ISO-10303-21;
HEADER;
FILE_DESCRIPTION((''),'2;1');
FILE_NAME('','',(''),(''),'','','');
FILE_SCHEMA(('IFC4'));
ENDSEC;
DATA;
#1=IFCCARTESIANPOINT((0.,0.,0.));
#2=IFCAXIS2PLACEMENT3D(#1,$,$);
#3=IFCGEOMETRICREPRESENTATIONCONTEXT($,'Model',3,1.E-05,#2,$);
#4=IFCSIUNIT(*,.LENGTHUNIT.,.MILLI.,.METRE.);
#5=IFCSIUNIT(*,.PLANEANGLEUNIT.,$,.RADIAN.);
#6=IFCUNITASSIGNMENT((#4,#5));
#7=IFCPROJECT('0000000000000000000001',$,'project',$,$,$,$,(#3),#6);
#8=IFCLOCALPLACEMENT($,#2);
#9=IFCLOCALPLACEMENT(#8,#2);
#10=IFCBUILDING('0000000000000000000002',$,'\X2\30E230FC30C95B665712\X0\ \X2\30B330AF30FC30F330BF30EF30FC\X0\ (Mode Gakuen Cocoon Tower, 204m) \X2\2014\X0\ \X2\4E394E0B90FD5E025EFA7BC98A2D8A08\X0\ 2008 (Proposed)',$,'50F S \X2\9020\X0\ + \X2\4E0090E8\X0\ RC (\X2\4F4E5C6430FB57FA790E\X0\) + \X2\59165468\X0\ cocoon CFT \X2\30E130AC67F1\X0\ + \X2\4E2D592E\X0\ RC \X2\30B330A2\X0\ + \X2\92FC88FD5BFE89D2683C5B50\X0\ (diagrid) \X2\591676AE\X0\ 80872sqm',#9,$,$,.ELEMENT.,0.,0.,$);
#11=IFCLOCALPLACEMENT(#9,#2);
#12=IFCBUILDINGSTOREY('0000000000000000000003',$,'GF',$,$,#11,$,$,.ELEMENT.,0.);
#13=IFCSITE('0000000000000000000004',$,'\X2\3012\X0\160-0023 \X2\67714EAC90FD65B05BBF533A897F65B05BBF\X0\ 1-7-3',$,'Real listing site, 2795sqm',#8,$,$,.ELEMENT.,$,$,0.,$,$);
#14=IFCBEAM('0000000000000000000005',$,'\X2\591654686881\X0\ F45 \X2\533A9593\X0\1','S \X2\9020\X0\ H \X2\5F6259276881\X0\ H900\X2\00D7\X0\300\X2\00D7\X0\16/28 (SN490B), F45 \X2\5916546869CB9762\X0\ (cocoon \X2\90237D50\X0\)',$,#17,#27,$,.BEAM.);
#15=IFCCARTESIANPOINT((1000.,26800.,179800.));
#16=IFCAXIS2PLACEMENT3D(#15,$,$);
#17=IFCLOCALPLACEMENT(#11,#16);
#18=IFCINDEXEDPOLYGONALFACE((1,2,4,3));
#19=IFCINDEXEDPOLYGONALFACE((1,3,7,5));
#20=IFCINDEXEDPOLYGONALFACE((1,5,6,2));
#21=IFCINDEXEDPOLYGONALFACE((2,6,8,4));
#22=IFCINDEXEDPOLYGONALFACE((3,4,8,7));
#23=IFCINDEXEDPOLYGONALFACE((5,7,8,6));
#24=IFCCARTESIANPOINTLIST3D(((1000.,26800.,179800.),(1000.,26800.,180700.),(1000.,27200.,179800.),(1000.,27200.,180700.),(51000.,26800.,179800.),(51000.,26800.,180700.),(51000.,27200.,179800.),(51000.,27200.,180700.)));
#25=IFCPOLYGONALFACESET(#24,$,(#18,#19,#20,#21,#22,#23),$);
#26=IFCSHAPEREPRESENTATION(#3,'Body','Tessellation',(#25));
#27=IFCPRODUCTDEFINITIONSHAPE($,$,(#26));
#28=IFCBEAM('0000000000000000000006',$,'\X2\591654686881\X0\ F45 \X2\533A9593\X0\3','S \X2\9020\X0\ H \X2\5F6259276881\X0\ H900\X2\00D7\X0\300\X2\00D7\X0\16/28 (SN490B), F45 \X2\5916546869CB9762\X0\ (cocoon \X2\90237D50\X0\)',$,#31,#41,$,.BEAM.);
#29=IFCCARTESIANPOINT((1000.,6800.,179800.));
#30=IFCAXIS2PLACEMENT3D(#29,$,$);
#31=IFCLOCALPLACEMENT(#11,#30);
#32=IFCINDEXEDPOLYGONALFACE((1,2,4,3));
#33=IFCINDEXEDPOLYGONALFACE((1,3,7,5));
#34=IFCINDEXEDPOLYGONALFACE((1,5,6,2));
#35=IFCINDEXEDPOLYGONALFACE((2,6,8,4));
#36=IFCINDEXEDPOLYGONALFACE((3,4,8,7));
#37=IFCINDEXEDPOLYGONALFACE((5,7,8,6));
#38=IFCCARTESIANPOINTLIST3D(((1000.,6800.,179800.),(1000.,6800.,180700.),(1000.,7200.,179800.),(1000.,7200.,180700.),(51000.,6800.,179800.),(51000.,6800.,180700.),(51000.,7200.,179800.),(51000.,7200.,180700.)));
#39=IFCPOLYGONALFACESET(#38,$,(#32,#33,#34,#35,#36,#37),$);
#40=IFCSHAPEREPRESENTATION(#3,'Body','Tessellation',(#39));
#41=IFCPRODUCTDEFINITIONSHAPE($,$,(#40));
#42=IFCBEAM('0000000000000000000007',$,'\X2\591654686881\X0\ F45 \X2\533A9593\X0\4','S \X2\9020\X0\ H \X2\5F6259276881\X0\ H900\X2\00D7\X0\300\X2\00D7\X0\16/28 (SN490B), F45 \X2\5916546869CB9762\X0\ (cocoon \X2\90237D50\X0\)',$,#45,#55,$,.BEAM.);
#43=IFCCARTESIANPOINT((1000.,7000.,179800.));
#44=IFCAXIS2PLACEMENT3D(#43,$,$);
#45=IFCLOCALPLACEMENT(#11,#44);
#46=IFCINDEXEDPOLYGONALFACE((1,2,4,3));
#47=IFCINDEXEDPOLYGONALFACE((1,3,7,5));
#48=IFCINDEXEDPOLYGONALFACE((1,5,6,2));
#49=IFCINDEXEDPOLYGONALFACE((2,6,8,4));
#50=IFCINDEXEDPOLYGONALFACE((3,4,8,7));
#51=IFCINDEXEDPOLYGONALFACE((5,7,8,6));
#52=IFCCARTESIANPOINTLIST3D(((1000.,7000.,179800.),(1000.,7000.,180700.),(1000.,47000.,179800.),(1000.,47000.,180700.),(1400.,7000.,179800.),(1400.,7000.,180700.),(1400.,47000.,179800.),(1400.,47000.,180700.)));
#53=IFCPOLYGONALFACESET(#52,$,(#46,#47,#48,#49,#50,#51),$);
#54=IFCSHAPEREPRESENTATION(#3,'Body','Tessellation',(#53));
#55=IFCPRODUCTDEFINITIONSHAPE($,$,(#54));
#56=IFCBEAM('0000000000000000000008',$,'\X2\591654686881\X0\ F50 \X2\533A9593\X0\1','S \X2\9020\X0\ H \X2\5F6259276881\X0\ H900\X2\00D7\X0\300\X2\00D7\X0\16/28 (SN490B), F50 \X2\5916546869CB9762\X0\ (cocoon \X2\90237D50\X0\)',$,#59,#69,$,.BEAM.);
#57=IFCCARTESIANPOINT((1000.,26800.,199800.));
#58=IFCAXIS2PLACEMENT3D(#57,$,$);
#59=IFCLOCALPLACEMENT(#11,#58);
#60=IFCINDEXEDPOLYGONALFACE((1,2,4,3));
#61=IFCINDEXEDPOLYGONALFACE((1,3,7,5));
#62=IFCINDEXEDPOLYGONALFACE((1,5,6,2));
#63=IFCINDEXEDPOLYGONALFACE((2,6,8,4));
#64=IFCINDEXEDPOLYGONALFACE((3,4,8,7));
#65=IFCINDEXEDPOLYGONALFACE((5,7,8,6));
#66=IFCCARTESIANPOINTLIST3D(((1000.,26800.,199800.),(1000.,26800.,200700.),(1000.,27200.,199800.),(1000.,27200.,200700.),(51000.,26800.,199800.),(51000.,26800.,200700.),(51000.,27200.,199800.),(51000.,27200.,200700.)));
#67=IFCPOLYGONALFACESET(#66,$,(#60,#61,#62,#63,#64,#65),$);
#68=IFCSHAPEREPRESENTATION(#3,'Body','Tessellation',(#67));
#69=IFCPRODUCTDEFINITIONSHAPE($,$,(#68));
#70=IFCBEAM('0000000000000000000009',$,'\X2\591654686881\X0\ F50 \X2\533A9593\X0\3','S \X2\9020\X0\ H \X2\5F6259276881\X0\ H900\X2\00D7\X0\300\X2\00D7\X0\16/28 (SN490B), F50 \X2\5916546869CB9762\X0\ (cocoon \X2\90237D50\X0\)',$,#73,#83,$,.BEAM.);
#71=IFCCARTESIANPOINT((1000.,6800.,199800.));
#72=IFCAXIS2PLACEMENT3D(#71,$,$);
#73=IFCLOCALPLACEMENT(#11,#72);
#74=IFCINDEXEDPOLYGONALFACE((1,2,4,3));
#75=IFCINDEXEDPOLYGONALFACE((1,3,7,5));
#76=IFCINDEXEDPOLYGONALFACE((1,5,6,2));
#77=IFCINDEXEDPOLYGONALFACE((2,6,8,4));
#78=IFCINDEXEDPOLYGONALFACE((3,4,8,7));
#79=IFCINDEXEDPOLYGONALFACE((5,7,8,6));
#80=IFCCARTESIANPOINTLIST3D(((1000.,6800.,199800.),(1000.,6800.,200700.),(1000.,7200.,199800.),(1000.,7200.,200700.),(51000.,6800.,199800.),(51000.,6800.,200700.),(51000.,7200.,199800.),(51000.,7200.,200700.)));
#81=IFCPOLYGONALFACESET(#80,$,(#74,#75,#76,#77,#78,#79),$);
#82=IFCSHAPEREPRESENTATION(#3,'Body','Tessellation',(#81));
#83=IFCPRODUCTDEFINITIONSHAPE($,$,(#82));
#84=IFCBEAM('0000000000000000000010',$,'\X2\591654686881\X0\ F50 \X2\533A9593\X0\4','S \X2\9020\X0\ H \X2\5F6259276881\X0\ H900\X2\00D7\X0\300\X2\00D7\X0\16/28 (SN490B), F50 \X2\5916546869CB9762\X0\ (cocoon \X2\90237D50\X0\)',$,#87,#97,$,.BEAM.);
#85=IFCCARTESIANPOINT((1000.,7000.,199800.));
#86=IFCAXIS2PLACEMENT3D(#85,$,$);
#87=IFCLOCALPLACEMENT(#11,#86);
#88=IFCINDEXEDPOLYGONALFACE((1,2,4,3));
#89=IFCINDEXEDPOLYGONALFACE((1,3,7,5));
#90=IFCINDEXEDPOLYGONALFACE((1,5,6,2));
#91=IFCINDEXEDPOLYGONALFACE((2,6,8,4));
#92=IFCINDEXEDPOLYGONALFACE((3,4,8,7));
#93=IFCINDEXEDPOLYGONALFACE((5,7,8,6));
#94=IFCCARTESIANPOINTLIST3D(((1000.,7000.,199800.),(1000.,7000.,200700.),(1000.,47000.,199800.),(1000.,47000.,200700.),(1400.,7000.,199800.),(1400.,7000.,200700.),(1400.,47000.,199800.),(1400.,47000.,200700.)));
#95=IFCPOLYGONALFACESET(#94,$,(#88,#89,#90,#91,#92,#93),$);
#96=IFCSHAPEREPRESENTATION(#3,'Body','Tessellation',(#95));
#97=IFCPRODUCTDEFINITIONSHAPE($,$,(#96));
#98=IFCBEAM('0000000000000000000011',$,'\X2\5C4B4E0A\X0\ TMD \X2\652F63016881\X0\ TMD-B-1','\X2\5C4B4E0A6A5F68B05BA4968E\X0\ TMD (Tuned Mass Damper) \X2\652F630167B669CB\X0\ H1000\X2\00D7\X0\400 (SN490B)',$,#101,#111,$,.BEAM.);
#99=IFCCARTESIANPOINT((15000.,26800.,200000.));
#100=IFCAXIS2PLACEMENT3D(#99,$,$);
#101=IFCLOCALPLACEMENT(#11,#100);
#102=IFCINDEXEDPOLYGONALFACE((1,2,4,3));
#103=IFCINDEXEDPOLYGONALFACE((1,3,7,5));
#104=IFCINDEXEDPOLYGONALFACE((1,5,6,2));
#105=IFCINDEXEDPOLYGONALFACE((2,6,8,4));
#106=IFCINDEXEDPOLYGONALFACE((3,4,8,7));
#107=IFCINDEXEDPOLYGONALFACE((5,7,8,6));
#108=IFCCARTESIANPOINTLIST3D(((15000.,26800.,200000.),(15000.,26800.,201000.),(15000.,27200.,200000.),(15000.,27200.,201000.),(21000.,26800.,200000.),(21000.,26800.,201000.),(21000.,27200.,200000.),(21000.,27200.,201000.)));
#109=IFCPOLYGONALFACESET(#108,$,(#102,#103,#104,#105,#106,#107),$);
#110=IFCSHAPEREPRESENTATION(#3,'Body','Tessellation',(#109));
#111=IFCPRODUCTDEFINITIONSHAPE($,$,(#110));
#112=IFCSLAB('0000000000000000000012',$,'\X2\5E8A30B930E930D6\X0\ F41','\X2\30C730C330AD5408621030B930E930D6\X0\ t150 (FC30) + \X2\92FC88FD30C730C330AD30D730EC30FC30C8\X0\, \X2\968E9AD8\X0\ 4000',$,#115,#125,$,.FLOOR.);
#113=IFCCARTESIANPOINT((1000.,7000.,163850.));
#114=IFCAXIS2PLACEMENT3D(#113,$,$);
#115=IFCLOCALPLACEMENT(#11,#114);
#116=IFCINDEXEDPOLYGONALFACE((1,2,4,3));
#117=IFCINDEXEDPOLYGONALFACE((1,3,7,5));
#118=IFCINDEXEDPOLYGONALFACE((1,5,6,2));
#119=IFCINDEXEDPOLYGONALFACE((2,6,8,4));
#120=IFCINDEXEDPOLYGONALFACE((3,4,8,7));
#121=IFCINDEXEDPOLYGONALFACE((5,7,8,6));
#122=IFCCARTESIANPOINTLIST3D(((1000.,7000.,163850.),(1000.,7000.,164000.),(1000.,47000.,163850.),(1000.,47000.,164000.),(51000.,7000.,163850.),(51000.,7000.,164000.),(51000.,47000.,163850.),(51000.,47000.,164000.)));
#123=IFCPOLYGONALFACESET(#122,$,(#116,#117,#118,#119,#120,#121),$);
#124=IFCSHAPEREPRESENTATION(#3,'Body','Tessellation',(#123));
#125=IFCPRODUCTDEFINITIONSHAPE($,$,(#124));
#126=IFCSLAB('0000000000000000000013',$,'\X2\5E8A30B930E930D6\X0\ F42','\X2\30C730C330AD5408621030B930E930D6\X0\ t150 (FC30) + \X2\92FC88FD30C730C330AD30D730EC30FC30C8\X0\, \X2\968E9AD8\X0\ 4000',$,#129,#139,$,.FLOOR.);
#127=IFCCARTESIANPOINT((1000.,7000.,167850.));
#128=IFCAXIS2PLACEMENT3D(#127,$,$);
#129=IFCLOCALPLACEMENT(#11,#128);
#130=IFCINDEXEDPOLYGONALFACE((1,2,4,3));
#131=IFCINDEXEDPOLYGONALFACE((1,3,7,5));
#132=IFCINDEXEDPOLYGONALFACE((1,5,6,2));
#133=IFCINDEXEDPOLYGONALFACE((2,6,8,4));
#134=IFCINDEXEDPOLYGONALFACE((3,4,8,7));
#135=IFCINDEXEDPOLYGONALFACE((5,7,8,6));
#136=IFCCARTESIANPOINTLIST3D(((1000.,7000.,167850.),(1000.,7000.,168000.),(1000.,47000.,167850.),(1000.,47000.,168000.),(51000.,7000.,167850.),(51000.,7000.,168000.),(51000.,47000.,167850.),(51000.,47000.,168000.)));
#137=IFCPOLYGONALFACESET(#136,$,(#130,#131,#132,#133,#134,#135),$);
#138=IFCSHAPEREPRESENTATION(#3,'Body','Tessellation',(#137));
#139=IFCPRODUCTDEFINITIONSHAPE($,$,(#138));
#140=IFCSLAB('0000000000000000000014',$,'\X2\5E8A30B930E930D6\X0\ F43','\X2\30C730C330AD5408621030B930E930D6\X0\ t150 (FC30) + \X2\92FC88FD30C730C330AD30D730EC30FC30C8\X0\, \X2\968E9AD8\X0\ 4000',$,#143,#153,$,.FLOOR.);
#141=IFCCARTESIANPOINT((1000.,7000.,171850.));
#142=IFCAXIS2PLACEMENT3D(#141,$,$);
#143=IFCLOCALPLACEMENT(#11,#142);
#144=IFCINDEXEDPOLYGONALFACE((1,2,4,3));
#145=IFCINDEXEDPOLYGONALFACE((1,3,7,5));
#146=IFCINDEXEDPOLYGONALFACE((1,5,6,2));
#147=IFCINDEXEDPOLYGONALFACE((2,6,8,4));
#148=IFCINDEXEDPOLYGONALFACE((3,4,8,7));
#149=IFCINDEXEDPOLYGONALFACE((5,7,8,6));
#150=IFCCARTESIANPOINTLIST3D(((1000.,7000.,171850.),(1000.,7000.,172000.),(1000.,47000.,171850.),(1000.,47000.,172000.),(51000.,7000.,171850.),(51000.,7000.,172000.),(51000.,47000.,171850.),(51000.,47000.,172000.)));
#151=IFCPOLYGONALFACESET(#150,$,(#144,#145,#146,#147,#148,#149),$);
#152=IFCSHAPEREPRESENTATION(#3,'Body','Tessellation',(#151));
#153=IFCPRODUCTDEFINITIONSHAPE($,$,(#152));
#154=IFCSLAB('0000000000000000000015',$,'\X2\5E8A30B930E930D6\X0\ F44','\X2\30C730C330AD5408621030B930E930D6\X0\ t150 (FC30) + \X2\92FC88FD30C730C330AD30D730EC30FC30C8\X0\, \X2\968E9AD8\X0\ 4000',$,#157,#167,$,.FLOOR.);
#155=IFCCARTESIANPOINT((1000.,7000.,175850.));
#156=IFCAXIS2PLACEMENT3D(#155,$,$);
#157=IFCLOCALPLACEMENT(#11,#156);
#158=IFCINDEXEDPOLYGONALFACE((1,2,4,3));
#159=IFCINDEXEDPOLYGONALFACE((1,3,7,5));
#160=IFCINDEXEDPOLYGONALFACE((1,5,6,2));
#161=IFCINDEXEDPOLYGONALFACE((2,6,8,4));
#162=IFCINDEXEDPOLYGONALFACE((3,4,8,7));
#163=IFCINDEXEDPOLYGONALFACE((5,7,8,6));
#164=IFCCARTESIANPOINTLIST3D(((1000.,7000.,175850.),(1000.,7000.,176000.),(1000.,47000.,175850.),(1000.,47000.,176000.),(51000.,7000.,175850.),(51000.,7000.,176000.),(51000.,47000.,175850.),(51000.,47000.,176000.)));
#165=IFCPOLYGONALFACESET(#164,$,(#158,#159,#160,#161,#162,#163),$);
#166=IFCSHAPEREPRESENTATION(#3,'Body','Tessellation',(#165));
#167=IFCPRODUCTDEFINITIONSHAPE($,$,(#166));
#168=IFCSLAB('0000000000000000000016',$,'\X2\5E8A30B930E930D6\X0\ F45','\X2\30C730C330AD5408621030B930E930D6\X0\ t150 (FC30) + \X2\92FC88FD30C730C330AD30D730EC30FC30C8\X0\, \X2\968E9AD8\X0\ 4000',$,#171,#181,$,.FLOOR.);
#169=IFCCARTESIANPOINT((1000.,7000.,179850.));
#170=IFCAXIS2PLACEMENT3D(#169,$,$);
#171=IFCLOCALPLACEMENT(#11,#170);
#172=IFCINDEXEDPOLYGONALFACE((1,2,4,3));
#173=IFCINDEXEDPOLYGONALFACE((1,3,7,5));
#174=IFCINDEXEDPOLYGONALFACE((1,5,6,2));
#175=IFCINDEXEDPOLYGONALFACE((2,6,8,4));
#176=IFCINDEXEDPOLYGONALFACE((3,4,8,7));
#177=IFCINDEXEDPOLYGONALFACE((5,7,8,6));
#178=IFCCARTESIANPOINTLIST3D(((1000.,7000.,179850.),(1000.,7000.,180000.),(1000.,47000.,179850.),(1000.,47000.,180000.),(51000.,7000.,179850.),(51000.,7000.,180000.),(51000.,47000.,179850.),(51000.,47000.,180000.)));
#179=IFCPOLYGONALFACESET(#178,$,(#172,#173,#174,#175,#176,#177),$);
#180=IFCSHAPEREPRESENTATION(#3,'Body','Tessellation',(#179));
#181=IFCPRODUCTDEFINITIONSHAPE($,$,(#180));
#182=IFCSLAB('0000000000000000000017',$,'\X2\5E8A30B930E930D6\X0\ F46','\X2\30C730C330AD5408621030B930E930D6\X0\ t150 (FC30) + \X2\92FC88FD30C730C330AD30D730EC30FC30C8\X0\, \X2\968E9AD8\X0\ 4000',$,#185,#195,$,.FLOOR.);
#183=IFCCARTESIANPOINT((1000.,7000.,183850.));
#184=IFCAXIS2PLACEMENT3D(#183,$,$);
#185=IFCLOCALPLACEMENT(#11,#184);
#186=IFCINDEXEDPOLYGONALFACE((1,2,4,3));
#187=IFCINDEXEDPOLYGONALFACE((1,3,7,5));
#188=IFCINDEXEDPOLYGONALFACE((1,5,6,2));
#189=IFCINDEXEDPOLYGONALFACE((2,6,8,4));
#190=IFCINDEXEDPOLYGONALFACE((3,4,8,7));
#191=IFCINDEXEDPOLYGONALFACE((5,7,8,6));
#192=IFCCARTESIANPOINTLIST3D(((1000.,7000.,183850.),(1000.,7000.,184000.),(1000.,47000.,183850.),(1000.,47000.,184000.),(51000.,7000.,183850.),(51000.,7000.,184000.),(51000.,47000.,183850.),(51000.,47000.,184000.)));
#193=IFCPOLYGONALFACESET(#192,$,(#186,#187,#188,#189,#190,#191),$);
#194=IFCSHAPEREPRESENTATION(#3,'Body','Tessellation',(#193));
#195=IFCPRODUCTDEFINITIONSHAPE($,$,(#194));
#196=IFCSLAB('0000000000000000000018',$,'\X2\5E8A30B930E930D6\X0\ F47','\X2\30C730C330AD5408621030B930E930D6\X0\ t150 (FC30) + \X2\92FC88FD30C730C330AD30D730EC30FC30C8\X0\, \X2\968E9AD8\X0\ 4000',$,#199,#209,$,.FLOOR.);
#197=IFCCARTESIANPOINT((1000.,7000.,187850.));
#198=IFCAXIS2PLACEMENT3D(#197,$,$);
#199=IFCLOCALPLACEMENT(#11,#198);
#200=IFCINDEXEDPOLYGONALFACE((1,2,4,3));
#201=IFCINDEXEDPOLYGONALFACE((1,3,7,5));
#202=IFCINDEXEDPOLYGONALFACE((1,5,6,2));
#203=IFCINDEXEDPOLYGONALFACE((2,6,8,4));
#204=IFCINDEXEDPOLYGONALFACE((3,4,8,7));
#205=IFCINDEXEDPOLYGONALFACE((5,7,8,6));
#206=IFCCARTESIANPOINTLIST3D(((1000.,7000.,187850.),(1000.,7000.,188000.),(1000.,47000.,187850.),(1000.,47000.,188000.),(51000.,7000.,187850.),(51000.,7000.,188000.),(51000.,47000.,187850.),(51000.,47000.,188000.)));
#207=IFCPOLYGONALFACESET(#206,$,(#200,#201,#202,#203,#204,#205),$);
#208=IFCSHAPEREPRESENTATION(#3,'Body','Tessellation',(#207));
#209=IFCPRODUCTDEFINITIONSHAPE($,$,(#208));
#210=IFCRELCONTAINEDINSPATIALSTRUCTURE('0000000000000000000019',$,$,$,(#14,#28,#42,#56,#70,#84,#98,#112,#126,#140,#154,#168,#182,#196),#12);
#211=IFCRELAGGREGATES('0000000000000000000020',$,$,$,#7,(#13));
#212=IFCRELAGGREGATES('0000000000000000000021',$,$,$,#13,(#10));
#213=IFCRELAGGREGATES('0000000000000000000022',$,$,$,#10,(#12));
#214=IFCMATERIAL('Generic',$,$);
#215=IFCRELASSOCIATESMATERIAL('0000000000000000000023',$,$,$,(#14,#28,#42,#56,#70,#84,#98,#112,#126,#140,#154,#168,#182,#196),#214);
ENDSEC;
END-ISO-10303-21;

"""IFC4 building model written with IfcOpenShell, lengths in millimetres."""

from ifc_helpers import new_model, si_unit, frame, frame_2d, origin, place, context, project, spatial, rectangle, extrude, material, element, save


model = new_model("IFC4")

# Units and contexts
model_context = context("Model", 3, precision=1e-05, world=origin())
ifc_project = project(units=[si_unit("LENGTHUNIT", "METRE", prefix="MILLI"), si_unit("PLANEANGLEUNIT", "RADIAN")], contexts=[model_context])

# Site, building, storey
site_placement = place(None, origin())
site = spatial("IfcSite", under=ifc_project, at=site_placement, Name="〒160-0023 東京都新宿区西新宿 1-7-3", ObjectType="Real listing site, 2795sqm", CompositionType="ELEMENT", RefElevation=0.0)
building_placement = place(site_placement, origin())
building = spatial("IfcBuilding", under=site, at=building_placement, Name="モード学園 コクーンタワー (Mode Gakuen Cocoon Tower, 204m) — 丹下都市建築設計 2008 (Proposed)", ObjectType="50F S 造 + 一部 RC (低層・基礎) + 外周 cocoon CFT メガ柱 + 中央 RC コア + 鋼製対角格子 (diagrid) 外皮 80872sqm", CompositionType="ELEMENT", ElevationOfRefHeight=0.0, ElevationOfTerrain=0.0)
storey_placement = place(building_placement, origin())
storey = spatial("IfcBuildingStorey", under=building, at=storey_placement, Name="GF", CompositionType="ELEMENT", Elevation=0.0)

# Beams
ifc_material_1 = material(Name="Generic")
beam_1_placement = place(storey_placement, frame((1000.0, 26800.0, 179800.0)))
element("IfcBeam", 1, at=beam_1_placement, inside=storey, material=ifc_material_1, Name="外周梁 F45 区間1", Description="S 造 H 形大梁 H900×300×16/28 (SN490B), F45 外周構面 (cocoon 連結)", PredefinedType="BEAM", context=model_context, shape_type="SweptSolid", body=[
    extrude(rectangle(XDim=50000.0, YDim=400.0, at=frame_2d((25000.0, 200.0))), frame((1000.0, 26800.0, 179800.0)), (0.0, 0.0, 1.0), 900.0),
])
beam_2_placement = place(storey_placement, frame((1000.0, 6800.0, 179800.0)))
element("IfcBeam", 2, at=beam_2_placement, inside=storey, material=ifc_material_1, Name="外周梁 F45 区間3", Description="S 造 H 形大梁 H900×300×16/28 (SN490B), F45 外周構面 (cocoon 連結)", PredefinedType="BEAM", context=model_context, shape_type="SweptSolid", body=[
    extrude(rectangle(XDim=50000.0, YDim=400.0, at=frame_2d((25000.0, 200.0))), frame((1000.0, 6800.0, 179800.0)), (0.0, 0.0, 1.0), 900.0),
])
beam_3_placement = place(storey_placement, frame((1000.0, 7000.0, 179800.0)))
element("IfcBeam", 3, at=beam_3_placement, inside=storey, material=ifc_material_1, Name="外周梁 F45 区間4", Description="S 造 H 形大梁 H900×300×16/28 (SN490B), F45 外周構面 (cocoon 連結)", PredefinedType="BEAM", context=model_context, shape_type="SweptSolid", body=[
    extrude(rectangle(XDim=400.0, YDim=40000.0, at=frame_2d((200.0, 20000.0))), frame((1000.0, 7000.0, 179800.0)), (0.0, 0.0, 1.0), 900.0),
])
beam_4_placement = place(storey_placement, frame((1000.0, 26800.0, 199800.0)))
element("IfcBeam", 4, at=beam_4_placement, inside=storey, material=ifc_material_1, Name="外周梁 F50 区間1", Description="S 造 H 形大梁 H900×300×16/28 (SN490B), F50 外周構面 (cocoon 連結)", PredefinedType="BEAM", context=model_context, shape_type="SweptSolid", body=[
    extrude(rectangle(XDim=50000.0, YDim=400.0, at=frame_2d((25000.0, 200.0))), frame((1000.0, 26800.0, 199800.0)), (0.0, 0.0, 1.0), 900.0),
])
beam_5_placement = place(storey_placement, frame((1000.0, 6800.0, 199800.0)))
element("IfcBeam", 5, at=beam_5_placement, inside=storey, material=ifc_material_1, Name="外周梁 F50 区間3", Description="S 造 H 形大梁 H900×300×16/28 (SN490B), F50 外周構面 (cocoon 連結)", PredefinedType="BEAM", context=model_context, shape_type="SweptSolid", body=[
    extrude(rectangle(XDim=50000.0, YDim=400.0, at=frame_2d((25000.0, 200.0))), frame((1000.0, 6800.0, 199800.0)), (0.0, 0.0, 1.0), 900.0),
])
beam_6_placement = place(storey_placement, frame((1000.0, 7000.0, 199800.0)))
element("IfcBeam", 6, at=beam_6_placement, inside=storey, material=ifc_material_1, Name="外周梁 F50 区間4", Description="S 造 H 形大梁 H900×300×16/28 (SN490B), F50 外周構面 (cocoon 連結)", PredefinedType="BEAM", context=model_context, shape_type="SweptSolid", body=[
    extrude(rectangle(XDim=400.0, YDim=40000.0, at=frame_2d((200.0, 20000.0))), frame((1000.0, 7000.0, 199800.0)), (0.0, 0.0, 1.0), 900.0),
])
beam_7_placement = place(storey_placement, frame((15000.0, 26800.0, 200000.0)))
element("IfcBeam", 7, at=beam_7_placement, inside=storey, material=ifc_material_1, Name="屋上 TMD 支持梁 TMD-B-1", Description="屋上機械室階 TMD (Tuned Mass Damper) 支持架構 H1000×400 (SN490B)", PredefinedType="BEAM", context=model_context, shape_type="SweptSolid", body=[
    extrude(rectangle(XDim=6000.0, YDim=400.0, at=frame_2d((3000.0, 200.0))), frame((15000.0, 26800.0, 200000.0)), (0.0, 0.0, 1.0), 1000.0),
])

# Slabs
slab_1_placement = place(storey_placement, frame((1000.0, 7000.0, 163850.0)))
element("IfcSlab", 8, at=slab_1_placement, inside=storey, material=ifc_material_1, Name="床スラブ F41", Description="デッキ合成スラブ t150 (FC30) + 鋼製デッキプレート, 階高 4000", PredefinedType="FLOOR", context=model_context, shape_type="SweptSolid", body=[
    extrude(rectangle(XDim=50000.0, YDim=40000.0, at=frame_2d((25000.0, 20000.0))), frame((1000.0, 7000.0, 163850.0)), (0.0, 0.0, 1.0), 150.0),
])
slab_2_placement = place(storey_placement, frame((1000.0, 7000.0, 167850.0)))
element("IfcSlab", 9, at=slab_2_placement, inside=storey, material=ifc_material_1, Name="床スラブ F42", Description="デッキ合成スラブ t150 (FC30) + 鋼製デッキプレート, 階高 4000", PredefinedType="FLOOR", context=model_context, shape_type="SweptSolid", body=[
    extrude(rectangle(XDim=50000.0, YDim=40000.0, at=frame_2d((25000.0, 20000.0))), frame((1000.0, 7000.0, 167850.0)), (0.0, 0.0, 1.0), 150.0),
])
slab_3_placement = place(storey_placement, frame((1000.0, 7000.0, 171850.0)))
element("IfcSlab", 10, at=slab_3_placement, inside=storey, material=ifc_material_1, Name="床スラブ F43", Description="デッキ合成スラブ t150 (FC30) + 鋼製デッキプレート, 階高 4000", PredefinedType="FLOOR", context=model_context, shape_type="SweptSolid", body=[
    extrude(rectangle(XDim=50000.0, YDim=40000.0, at=frame_2d((25000.0, 20000.0))), frame((1000.0, 7000.0, 171850.0)), (0.0, 0.0, 1.0), 150.0),
])
slab_4_placement = place(storey_placement, frame((1000.0, 7000.0, 175850.0)))
element("IfcSlab", 11, at=slab_4_placement, inside=storey, material=ifc_material_1, Name="床スラブ F44", Description="デッキ合成スラブ t150 (FC30) + 鋼製デッキプレート, 階高 4000", PredefinedType="FLOOR", context=model_context, shape_type="SweptSolid", body=[
    extrude(rectangle(XDim=50000.0, YDim=40000.0, at=frame_2d((25000.0, 20000.0))), frame((1000.0, 7000.0, 175850.0)), (0.0, 0.0, 1.0), 150.0),
])
slab_5_placement = place(storey_placement, frame((1000.0, 7000.0, 179850.0)))
element("IfcSlab", 12, at=slab_5_placement, inside=storey, material=ifc_material_1, Name="床スラブ F45", Description="デッキ合成スラブ t150 (FC30) + 鋼製デッキプレート, 階高 4000", PredefinedType="FLOOR", context=model_context, shape_type="SweptSolid", body=[
    extrude(rectangle(XDim=50000.0, YDim=40000.0, at=frame_2d((25000.0, 20000.0))), frame((1000.0, 7000.0, 179850.0)), (0.0, 0.0, 1.0), 150.0),
])
slab_6_placement = place(storey_placement, frame((1000.0, 7000.0, 183850.0)))
element("IfcSlab", 13, at=slab_6_placement, inside=storey, material=ifc_material_1, Name="床スラブ F46", Description="デッキ合成スラブ t150 (FC30) + 鋼製デッキプレート, 階高 4000", PredefinedType="FLOOR", context=model_context, shape_type="SweptSolid", body=[
    extrude(rectangle(XDim=50000.0, YDim=40000.0, at=frame_2d((25000.0, 20000.0))), frame((1000.0, 7000.0, 183850.0)), (0.0, 0.0, 1.0), 150.0),
])
slab_7_placement = place(storey_placement, frame((1000.0, 7000.0, 187850.0)))
element("IfcSlab", 14, at=slab_7_placement, inside=storey, material=ifc_material_1, Name="床スラブ F47", Description="デッキ合成スラブ t150 (FC30) + 鋼製デッキプレート, 階高 4000", PredefinedType="FLOOR", context=model_context, shape_type="SweptSolid", body=[
    extrude(rectangle(XDim=50000.0, YDim=40000.0, at=frame_2d((25000.0, 20000.0))), frame((1000.0, 7000.0, 187850.0)), (0.0, 0.0, 1.0), 150.0),
])

save(model, "model.ifc")
